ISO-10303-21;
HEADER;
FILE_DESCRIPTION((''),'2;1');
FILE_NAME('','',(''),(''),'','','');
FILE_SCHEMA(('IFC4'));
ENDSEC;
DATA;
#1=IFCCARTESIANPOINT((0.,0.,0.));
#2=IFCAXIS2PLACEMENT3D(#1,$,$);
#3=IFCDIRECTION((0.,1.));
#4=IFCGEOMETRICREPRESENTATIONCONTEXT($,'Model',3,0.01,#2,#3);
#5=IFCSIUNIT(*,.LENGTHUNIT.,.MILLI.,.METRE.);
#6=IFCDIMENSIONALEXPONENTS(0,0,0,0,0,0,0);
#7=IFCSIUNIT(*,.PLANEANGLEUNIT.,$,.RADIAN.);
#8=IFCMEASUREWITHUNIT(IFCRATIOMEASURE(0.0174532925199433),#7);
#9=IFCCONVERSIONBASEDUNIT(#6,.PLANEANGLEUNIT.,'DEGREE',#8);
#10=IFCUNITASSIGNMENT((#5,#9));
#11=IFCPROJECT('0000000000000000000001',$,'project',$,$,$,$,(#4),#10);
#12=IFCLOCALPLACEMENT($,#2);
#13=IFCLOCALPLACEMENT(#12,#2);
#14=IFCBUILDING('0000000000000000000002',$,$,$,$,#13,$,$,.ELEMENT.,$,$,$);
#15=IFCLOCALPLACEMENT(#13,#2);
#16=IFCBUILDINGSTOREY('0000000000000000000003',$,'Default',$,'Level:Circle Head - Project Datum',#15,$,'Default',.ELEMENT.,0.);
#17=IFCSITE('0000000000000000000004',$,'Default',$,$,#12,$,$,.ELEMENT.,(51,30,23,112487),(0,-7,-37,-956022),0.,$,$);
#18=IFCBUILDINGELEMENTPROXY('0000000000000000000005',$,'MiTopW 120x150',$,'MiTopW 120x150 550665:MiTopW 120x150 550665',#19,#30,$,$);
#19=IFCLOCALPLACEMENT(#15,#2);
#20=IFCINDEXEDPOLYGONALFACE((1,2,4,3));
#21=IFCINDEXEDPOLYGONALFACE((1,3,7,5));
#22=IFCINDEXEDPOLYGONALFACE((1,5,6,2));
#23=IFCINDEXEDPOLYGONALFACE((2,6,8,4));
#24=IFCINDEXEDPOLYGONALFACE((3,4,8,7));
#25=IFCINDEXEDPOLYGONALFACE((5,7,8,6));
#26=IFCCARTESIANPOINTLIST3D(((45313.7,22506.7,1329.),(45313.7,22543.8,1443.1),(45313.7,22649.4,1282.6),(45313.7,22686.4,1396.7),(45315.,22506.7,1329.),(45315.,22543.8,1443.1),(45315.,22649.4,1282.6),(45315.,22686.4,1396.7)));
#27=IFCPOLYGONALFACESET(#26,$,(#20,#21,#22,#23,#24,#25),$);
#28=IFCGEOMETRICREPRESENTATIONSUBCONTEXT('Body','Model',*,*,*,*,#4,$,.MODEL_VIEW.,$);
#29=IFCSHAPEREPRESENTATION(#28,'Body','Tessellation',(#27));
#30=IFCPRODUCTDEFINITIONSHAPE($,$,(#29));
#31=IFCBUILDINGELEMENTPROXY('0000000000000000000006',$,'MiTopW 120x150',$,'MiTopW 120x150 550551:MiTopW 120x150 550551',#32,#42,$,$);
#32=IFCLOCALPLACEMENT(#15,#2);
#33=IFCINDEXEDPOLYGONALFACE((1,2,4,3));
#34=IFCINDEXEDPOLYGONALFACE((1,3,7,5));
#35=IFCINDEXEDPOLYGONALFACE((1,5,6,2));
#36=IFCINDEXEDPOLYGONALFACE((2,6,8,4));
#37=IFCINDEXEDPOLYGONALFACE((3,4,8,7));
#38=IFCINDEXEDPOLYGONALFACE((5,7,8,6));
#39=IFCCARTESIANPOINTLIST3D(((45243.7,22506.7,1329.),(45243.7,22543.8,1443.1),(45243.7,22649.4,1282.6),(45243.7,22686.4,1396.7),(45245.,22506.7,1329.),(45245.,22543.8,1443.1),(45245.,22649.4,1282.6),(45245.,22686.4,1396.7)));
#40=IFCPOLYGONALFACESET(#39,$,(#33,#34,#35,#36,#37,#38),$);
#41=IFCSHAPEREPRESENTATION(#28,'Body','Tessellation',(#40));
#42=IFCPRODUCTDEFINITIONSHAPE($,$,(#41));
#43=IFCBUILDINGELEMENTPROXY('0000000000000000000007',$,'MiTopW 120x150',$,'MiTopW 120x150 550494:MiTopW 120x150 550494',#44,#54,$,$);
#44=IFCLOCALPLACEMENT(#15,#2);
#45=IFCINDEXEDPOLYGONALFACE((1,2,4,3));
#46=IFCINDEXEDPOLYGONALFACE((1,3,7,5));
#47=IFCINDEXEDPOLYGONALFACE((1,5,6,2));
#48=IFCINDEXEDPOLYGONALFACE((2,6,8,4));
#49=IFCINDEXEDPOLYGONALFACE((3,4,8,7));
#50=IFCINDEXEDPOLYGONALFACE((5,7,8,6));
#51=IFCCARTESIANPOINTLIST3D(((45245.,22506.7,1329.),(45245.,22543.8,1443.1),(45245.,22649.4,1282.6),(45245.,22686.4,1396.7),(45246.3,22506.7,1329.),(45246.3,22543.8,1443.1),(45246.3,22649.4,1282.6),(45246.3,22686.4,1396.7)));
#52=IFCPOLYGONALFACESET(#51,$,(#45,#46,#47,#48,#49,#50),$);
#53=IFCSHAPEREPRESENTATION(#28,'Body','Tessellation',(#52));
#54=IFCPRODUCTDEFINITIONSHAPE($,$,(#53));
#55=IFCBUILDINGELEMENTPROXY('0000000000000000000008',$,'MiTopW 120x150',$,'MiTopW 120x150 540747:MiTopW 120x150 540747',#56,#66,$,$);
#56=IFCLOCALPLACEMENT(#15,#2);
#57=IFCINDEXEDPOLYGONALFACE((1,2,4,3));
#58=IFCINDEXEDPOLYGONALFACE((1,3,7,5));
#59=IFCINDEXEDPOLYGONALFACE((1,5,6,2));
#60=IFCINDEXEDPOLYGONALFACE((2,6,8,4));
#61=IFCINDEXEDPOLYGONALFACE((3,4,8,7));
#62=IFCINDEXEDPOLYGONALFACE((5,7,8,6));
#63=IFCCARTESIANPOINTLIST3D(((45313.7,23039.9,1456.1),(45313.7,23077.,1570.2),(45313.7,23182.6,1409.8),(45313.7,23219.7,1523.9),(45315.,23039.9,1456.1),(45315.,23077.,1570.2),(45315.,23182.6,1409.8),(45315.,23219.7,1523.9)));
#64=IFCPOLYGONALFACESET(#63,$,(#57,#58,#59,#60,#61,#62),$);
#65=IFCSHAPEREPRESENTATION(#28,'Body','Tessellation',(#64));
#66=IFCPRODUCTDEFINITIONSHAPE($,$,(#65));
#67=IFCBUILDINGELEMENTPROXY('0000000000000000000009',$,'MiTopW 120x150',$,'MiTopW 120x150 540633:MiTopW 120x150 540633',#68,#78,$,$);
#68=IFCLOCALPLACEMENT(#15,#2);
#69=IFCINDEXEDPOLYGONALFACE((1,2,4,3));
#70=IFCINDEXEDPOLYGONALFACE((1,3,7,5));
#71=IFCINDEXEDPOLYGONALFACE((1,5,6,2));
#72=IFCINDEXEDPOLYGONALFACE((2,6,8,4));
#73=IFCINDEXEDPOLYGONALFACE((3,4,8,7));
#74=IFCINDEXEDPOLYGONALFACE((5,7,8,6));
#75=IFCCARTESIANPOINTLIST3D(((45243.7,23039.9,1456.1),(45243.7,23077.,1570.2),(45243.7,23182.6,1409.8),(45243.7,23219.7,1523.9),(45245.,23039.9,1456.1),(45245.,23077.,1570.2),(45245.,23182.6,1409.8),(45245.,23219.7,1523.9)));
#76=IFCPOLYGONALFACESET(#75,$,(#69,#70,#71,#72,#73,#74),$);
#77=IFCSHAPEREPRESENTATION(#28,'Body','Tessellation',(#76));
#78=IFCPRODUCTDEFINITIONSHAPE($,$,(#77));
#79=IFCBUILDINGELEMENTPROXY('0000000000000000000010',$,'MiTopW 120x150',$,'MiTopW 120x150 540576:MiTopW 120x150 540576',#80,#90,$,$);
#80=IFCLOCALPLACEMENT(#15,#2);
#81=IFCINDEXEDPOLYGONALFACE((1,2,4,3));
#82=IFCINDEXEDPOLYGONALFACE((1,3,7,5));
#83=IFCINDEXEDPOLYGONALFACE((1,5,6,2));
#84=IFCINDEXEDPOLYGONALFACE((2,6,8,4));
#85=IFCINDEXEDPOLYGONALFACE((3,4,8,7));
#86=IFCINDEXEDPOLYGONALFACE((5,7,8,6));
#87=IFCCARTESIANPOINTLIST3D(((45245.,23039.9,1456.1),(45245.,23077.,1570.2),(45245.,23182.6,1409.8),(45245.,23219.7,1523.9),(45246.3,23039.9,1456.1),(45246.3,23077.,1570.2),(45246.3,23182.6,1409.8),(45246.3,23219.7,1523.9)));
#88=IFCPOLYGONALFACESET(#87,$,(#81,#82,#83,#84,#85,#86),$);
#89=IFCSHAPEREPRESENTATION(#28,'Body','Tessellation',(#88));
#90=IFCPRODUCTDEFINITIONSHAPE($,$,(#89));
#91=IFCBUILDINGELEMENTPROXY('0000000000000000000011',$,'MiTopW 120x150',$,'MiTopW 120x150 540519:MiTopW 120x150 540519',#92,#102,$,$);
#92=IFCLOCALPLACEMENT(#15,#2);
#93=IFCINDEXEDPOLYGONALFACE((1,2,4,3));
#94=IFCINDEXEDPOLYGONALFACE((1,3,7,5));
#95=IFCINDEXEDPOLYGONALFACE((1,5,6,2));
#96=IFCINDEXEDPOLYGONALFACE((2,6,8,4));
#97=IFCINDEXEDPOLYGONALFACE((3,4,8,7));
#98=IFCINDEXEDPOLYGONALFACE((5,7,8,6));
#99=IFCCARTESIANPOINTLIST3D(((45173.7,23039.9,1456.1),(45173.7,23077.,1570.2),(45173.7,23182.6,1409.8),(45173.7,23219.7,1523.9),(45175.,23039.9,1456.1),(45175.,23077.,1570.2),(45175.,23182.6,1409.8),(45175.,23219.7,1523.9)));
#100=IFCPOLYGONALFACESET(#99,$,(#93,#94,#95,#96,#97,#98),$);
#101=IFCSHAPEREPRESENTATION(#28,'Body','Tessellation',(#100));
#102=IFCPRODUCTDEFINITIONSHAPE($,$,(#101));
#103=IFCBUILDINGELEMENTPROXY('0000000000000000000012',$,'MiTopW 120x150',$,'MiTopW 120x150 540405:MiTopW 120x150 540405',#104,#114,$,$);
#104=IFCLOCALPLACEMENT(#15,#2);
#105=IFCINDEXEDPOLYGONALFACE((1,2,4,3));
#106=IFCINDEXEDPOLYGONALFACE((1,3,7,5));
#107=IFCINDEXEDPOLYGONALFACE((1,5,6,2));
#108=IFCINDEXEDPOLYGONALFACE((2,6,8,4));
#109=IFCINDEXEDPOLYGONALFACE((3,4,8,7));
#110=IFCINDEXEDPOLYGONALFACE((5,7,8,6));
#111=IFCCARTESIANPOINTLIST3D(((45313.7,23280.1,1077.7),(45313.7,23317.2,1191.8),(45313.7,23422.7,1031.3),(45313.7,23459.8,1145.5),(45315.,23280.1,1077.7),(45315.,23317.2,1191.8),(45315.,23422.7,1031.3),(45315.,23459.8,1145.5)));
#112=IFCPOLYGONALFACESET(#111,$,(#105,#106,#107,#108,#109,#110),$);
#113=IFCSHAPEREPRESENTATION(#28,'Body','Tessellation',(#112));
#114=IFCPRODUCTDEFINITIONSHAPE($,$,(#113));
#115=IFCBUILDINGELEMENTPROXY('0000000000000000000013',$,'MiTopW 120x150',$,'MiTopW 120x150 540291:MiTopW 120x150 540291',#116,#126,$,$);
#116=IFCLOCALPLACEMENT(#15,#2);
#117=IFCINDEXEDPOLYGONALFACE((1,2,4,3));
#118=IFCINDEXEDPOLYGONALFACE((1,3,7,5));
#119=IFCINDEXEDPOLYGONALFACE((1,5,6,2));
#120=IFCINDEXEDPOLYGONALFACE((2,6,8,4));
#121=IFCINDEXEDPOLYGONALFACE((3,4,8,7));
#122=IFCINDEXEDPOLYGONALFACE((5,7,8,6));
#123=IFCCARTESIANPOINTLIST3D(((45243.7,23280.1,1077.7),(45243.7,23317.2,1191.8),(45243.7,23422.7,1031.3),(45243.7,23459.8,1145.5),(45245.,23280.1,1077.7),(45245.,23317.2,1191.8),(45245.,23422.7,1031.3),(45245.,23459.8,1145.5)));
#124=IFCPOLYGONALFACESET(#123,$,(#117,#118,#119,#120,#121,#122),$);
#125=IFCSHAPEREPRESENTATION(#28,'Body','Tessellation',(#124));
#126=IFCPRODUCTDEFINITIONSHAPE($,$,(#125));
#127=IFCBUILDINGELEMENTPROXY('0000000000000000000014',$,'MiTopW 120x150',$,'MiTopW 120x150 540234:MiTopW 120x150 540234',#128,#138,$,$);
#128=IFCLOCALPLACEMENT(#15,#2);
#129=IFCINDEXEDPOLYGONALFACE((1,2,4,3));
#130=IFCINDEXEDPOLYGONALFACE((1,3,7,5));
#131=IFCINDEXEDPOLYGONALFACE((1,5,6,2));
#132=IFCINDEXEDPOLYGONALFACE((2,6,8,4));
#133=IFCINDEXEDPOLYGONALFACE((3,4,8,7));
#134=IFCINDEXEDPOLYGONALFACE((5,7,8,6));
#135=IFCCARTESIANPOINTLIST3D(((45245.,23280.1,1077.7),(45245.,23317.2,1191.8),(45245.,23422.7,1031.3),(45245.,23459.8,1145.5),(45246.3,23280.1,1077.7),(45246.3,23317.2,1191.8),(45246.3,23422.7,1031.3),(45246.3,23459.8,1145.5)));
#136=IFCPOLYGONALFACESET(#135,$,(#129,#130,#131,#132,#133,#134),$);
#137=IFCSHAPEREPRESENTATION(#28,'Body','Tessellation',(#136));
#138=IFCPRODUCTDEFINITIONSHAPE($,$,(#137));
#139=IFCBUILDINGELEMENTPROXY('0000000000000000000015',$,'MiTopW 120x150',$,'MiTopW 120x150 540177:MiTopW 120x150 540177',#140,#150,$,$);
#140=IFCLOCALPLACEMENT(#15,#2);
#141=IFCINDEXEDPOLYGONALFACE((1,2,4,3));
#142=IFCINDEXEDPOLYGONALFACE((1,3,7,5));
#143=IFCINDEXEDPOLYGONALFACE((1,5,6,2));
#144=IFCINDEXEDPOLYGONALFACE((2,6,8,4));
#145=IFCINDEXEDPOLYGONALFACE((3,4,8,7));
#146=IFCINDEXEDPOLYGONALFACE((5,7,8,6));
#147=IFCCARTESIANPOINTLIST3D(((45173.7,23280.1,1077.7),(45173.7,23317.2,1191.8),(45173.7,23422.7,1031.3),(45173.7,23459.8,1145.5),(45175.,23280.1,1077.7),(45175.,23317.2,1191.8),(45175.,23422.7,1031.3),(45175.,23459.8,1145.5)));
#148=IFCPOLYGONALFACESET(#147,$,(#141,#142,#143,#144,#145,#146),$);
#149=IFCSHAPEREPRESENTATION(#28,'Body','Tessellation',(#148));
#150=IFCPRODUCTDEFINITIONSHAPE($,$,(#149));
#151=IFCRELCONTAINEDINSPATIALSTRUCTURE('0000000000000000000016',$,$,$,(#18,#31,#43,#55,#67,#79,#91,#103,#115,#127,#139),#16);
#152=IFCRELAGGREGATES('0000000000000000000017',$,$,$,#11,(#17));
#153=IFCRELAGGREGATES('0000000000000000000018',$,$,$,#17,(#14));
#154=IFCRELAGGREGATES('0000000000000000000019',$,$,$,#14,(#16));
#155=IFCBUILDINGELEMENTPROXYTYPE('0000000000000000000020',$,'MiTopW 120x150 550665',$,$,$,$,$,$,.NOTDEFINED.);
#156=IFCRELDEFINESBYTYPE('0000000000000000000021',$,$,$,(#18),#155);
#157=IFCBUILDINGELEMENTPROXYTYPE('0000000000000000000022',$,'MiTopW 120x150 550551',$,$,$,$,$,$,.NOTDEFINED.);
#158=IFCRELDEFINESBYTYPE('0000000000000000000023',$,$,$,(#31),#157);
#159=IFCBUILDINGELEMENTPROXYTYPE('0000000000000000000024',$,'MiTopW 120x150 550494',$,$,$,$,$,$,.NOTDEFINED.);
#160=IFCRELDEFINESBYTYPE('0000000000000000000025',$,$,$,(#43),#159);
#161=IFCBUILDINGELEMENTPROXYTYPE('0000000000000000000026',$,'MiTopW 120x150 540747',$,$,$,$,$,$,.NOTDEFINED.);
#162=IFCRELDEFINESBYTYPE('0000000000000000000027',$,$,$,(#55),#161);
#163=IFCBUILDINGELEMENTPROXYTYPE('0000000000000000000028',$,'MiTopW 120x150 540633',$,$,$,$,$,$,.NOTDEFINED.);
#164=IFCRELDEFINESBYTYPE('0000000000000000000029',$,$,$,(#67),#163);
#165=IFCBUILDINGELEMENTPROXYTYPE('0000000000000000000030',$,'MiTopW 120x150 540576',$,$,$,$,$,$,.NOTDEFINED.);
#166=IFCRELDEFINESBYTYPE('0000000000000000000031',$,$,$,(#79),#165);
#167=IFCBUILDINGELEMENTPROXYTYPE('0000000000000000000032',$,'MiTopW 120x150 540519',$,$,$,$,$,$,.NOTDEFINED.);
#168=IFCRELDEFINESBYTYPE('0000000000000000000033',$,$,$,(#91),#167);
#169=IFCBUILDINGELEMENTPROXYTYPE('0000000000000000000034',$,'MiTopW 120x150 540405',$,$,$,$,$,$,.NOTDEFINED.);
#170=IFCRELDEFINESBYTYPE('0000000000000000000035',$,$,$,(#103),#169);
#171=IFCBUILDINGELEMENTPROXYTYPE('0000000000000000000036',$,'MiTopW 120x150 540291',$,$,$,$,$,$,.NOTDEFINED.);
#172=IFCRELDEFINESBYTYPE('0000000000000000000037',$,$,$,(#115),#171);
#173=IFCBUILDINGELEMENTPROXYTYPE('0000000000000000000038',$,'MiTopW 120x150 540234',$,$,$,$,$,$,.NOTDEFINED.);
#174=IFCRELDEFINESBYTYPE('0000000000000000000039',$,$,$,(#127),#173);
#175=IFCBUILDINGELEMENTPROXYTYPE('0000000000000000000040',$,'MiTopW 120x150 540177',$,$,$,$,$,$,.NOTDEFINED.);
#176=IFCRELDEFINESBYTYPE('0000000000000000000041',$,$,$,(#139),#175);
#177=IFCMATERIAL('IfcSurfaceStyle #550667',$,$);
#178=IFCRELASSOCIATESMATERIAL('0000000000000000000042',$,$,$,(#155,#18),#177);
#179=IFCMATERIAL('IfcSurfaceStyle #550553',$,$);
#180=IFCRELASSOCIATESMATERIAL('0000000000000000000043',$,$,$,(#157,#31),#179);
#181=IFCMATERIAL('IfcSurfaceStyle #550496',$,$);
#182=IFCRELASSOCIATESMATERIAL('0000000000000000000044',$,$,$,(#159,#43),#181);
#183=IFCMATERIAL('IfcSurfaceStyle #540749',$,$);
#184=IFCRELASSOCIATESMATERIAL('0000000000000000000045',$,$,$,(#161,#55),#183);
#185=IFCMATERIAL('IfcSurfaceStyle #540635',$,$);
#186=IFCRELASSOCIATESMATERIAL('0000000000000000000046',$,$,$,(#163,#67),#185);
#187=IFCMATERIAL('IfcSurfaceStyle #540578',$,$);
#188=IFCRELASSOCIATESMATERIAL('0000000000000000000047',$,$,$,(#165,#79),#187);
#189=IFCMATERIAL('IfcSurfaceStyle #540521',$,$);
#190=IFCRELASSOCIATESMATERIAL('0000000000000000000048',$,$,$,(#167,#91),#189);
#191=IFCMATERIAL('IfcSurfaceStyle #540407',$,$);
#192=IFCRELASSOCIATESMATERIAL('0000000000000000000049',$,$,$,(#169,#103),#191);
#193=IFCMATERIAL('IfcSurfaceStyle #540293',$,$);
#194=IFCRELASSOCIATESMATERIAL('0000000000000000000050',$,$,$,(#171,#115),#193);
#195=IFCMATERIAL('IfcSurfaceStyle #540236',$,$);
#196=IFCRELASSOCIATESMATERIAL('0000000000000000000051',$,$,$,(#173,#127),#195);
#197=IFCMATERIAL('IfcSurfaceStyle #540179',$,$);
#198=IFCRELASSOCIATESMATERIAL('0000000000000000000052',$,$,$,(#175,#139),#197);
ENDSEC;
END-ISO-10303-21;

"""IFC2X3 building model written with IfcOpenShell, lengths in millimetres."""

from ifc_helpers import new_model, entity, si_unit, converted_unit, direction, frame, origin, place, context, subcontext, project, spatial, polyline, outline, extrude, source, transform, mapped, material, type_object, type_shapes, element, save


model = new_model("IFC2X3")

# Units and contexts
model_context = context("Model", 3, precision=0.01, world=origin(), true_north=direction((0.0, 1.0)))
body_context = subcontext(model_context, "Body", "Model", "MODEL_VIEW")
ifc_project = project(units=[si_unit("LENGTHUNIT", "METRE", prefix="MILLI"), converted_unit("PLANEANGLEUNIT", "DEGREE", entity("IfcRatioMeasure", 0.0174532925199433), si_unit("PLANEANGLEUNIT", "RADIAN"), dimensions=[0, 0, 0, 0, 0, 0, 0])], contexts=[model_context])

# Site, building, storey
site_placement = place(None, origin())
site = spatial("IfcSite", under=ifc_project, at=site_placement, Name="Default", CompositionType="ELEMENT", RefLatitude=(51, 30, 23, 112487), RefLongitude=(0, -7, -37, -956022), RefElevation=0.0)
building_placement = place(site_placement, origin())
building = spatial("IfcBuilding", under=site, at=building_placement, CompositionType="ELEMENT")
storey_placement = place(building_placement, origin())
storey = spatial("IfcBuildingStorey", under=building, at=storey_placement, Name="Default", ObjectType="Level:Circle Head - Project Datum", LongName="Default", CompositionType="ELEMENT", Elevation=0.0)

# Building element proxies
ifc_material_1 = material(Name="IfcSurfaceStyle #550667")
building_element_proxy_type_1 = type_object("IfcBuildingElementProxyType", Name="MiTopW 120x150 550665", PredefinedType="NOTDEFINED", material=ifc_material_1)
shared_shape_1 = source(origin(), body_context, "Body", "SweptSolid", [
    extrude(outline(polyline([(-75.0, -60.0), (75.0, -60.0), (75.0, 60.0), (-75.0, 60.0), (-75.0, -60.0)])), frame((75.0, 60.0, 0.0), z_axis=(0.0, 0.0, 1.0), x_axis=(-1.0, 0.0, 0.0)), (0.0, 0.0, 1.0), 1.3),
])
type_shapes(building_element_proxy_type_1, [shared_shape_1])
proxy_1_placement = place(building_placement, frame((45315.0, 22649.4, 1282.6), z_axis=(-1.0, 0.0, 0.0), x_axis=(0.0, -0.951057, 0.309017)))
element("IfcBuildingElementProxy", 1, at=proxy_1_placement, inside=storey, type_object=building_element_proxy_type_1, material=ifc_material_1, Name="MiTopW 120x150", ObjectType="MiTopW 120x150 550665:MiTopW 120x150 550665", context=body_context, shape_type="MappedRepresentation", body=[
    mapped(shared_shape_1, transform((0.0, 0.0, 0.0), scale=1.0)),
])
ifc_material_2 = material(Name="IfcSurfaceStyle #550553")
building_element_proxy_type_2 = type_object("IfcBuildingElementProxyType", Name="MiTopW 120x150 550551", PredefinedType="NOTDEFINED", material=ifc_material_2)
shared_shape_2 = source(origin(), body_context, "Body", "SweptSolid", [
    extrude(outline(polyline([(-75.0, -60.0), (75.0, -60.0), (75.0, 60.0), (-75.0, 60.0), (-75.0, -60.0)])), frame((75.0, 60.0, 0.0), z_axis=(0.0, 0.0, 1.0), x_axis=(-1.0, 0.0, 0.0)), (0.0, 0.0, 1.0), 1.3),
])
type_shapes(building_element_proxy_type_2, [shared_shape_2])
proxy_2_placement = place(building_placement, frame((45245.0, 22649.4, 1282.6), z_axis=(-1.0, 0.0, 0.0), x_axis=(0.0, -0.951057, 0.309017)))
element("IfcBuildingElementProxy", 2, at=proxy_2_placement, inside=storey, type_object=building_element_proxy_type_2, material=ifc_material_2, Name="MiTopW 120x150", ObjectType="MiTopW 120x150 550551:MiTopW 120x150 550551", context=body_context, shape_type="MappedRepresentation", body=[
    mapped(shared_shape_2, transform((0.0, 0.0, 0.0), scale=1.0)),
])
ifc_material_3 = material(Name="IfcSurfaceStyle #550496")
building_element_proxy_type_3 = type_object("IfcBuildingElementProxyType", Name="MiTopW 120x150 550494", PredefinedType="NOTDEFINED", material=ifc_material_3)
shared_shape_3 = source(origin(), body_context, "Body", "SweptSolid", [
    extrude(outline(polyline([(-75.0, -60.0), (75.0, -60.0), (75.0, 60.0), (-75.0, 60.0), (-75.0, -60.0)])), frame((75.0, 60.0, 0.0), z_axis=(0.0, 0.0, 1.0), x_axis=(-1.0, 0.0, 0.0)), (0.0, 0.0, 1.0), 1.3),
])
type_shapes(building_element_proxy_type_3, [shared_shape_3])
proxy_3_placement = place(building_placement, frame((45246.3, 22649.4, 1282.6), z_axis=(-1.0, 0.0, 0.0), x_axis=(0.0, -0.951057, 0.309017)))
element("IfcBuildingElementProxy", 3, at=proxy_3_placement, inside=storey, type_object=building_element_proxy_type_3, material=ifc_material_3, Name="MiTopW 120x150", ObjectType="MiTopW 120x150 550494:MiTopW 120x150 550494", context=body_context, shape_type="MappedRepresentation", body=[
    mapped(shared_shape_3, transform((0.0, 0.0, 0.0), scale=1.0)),
])
ifc_material_4 = material(Name="IfcSurfaceStyle #540749")
building_element_proxy_type_4 = type_object("IfcBuildingElementProxyType", Name="MiTopW 120x150 540747", PredefinedType="NOTDEFINED", material=ifc_material_4)
shared_shape_4 = source(origin(), body_context, "Body", "SweptSolid", [
    extrude(outline(polyline([(-75.0, -60.0), (75.0, -60.0), (75.0, 60.0), (-75.0, 60.0), (-75.0, -60.0)])), frame((75.0, 60.0, 0.0), z_axis=(0.0, 0.0, 1.0), x_axis=(-1.0, 0.0, 0.0)), (0.0, 0.0, 1.0), 1.3),
])
type_shapes(building_element_proxy_type_4, [shared_shape_4])
proxy_4_placement = place(building_placement, frame((45315.0, 23182.6, 1409.8), z_axis=(-1.0, 0.0, 0.0), x_axis=(0.0, -0.951057, 0.309017)))
element("IfcBuildingElementProxy", 4, at=proxy_4_placement, inside=storey, type_object=building_element_proxy_type_4, material=ifc_material_4, Name="MiTopW 120x150", ObjectType="MiTopW 120x150 540747:MiTopW 120x150 540747", context=body_context, shape_type="MappedRepresentation", body=[
    mapped(shared_shape_4, transform((0.0, 0.0, 0.0), scale=1.0)),
])
ifc_material_5 = material(Name="IfcSurfaceStyle #540635")
building_element_proxy_type_5 = type_object("IfcBuildingElementProxyType", Name="MiTopW 120x150 540633", PredefinedType="NOTDEFINED", material=ifc_material_5)
shared_shape_5 = source(origin(), body_context, "Body", "SweptSolid", [
    extrude(outline(polyline([(-75.0, -60.0), (75.0, -60.0), (75.0, 60.0), (-75.0, 60.0), (-75.0, -60.0)])), frame((75.0, 60.0, 0.0), z_axis=(0.0, 0.0, 1.0), x_axis=(-1.0, 0.0, 0.0)), (0.0, 0.0, 1.0), 1.3),
])
type_shapes(building_element_proxy_type_5, [shared_shape_5])
proxy_5_placement = place(building_placement, frame((45245.0, 23182.6, 1409.8), z_axis=(-1.0, 0.0, 0.0), x_axis=(0.0, -0.951057, 0.309017)))
element("IfcBuildingElementProxy", 5, at=proxy_5_placement, inside=storey, type_object=building_element_proxy_type_5, material=ifc_material_5, Name="MiTopW 120x150", ObjectType="MiTopW 120x150 540633:MiTopW 120x150 540633", context=body_context, shape_type="MappedRepresentation", body=[
    mapped(shared_shape_5, transform((0.0, 0.0, 0.0), scale=1.0)),
])
ifc_material_6 = material(Name="IfcSurfaceStyle #540578")
building_element_proxy_type_6 = type_object("IfcBuildingElementProxyType", Name="MiTopW 120x150 540576", PredefinedType="NOTDEFINED", material=ifc_material_6)
shared_shape_6 = source(origin(), body_context, "Body", "SweptSolid", [
    extrude(outline(polyline([(-75.0, -60.0), (75.0, -60.0), (75.0, 60.0), (-75.0, 60.0), (-75.0, -60.0)])), frame((75.0, 60.0, 0.0), z_axis=(0.0, 0.0, 1.0), x_axis=(-1.0, 0.0, 0.0)), (0.0, 0.0, 1.0), 1.3),
])
type_shapes(building_element_proxy_type_6, [shared_shape_6])
proxy_6_placement = place(building_placement, frame((45246.3, 23182.6, 1409.8), z_axis=(-1.0, 0.0, 0.0), x_axis=(0.0, -0.951057, 0.309017)))
element("IfcBuildingElementProxy", 6, at=proxy_6_placement, inside=storey, type_object=building_element_proxy_type_6, material=ifc_material_6, Name="MiTopW 120x150", ObjectType="MiTopW 120x150 540576:MiTopW 120x150 540576", context=body_context, shape_type="MappedRepresentation", body=[
    mapped(shared_shape_6, transform((0.0, 0.0, 0.0), scale=1.0)),
])
ifc_material_7 = material(Name="IfcSurfaceStyle #540521")
building_element_proxy_type_7 = type_object("IfcBuildingElementProxyType", Name="MiTopW 120x150 540519", PredefinedType="NOTDEFINED", material=ifc_material_7)
shared_shape_7 = source(origin(), body_context, "Body", "SweptSolid", [
    extrude(outline(polyline([(-75.0, -60.0), (75.0, -60.0), (75.0, 60.0), (-75.0, 60.0), (-75.0, -60.0)])), frame((75.0, 60.0, 0.0), z_axis=(0.0, 0.0, 1.0), x_axis=(-1.0, 0.0, 0.0)), (0.0, 0.0, 1.0), 1.3),
])
type_shapes(building_element_proxy_type_7, [shared_shape_7])
proxy_7_placement = place(building_placement, frame((45175.0, 23182.6, 1409.8), z_axis=(-1.0, 0.0, 0.0), x_axis=(0.0, -0.951057, 0.309017)))
element("IfcBuildingElementProxy", 7, at=proxy_7_placement, inside=storey, type_object=building_element_proxy_type_7, material=ifc_material_7, Name="MiTopW 120x150", ObjectType="MiTopW 120x150 540519:MiTopW 120x150 540519", context=body_context, shape_type="MappedRepresentation", body=[
    mapped(shared_shape_7, transform((0.0, 0.0, 0.0), scale=1.0)),
])
ifc_material_8 = material(Name="IfcSurfaceStyle #540407")
building_element_proxy_type_8 = type_object("IfcBuildingElementProxyType", Name="MiTopW 120x150 540405", PredefinedType="NOTDEFINED", material=ifc_material_8)
shared_shape_8 = source(origin(), body_context, "Body", "SweptSolid", [
    extrude(outline(polyline([(-75.0, -60.0), (75.0, -60.0), (75.0, 60.0), (-75.0, 60.0), (-75.0, -60.0)])), frame((75.0, 60.0, 0.0), z_axis=(0.0, 0.0, 1.0), x_axis=(-1.0, 0.0, 0.0)), (0.0, 0.0, 1.0), 1.3),
])
type_shapes(building_element_proxy_type_8, [shared_shape_8])
proxy_8_placement = place(building_placement, frame((45315.0, 23422.7, 1031.3), z_axis=(-1.0, 0.0, 0.0), x_axis=(0.0, -0.951057, 0.309017)))
element("IfcBuildingElementProxy", 8, at=proxy_8_placement, inside=storey, type_object=building_element_proxy_type_8, material=ifc_material_8, Name="MiTopW 120x150", ObjectType="MiTopW 120x150 540405:MiTopW 120x150 540405", context=body_context, shape_type="MappedRepresentation", body=[
    mapped(shared_shape_8, transform((0.0, 0.0, 0.0), scale=1.0)),
])
ifc_material_9 = material(Name="IfcSurfaceStyle #540293")
building_element_proxy_type_9 = type_object("IfcBuildingElementProxyType", Name="MiTopW 120x150 540291", PredefinedType="NOTDEFINED", material=ifc_material_9)
shared_shape_9 = source(origin(), body_context, "Body", "SweptSolid", [
    extrude(outline(polyline([(-75.0, -60.0), (75.0, -60.0), (75.0, 60.0), (-75.0, 60.0), (-75.0, -60.0)])), frame((75.0, 60.0, 0.0), z_axis=(0.0, 0.0, 1.0), x_axis=(-1.0, 0.0, 0.0)), (0.0, 0.0, 1.0), 1.3),
])
type_shapes(building_element_proxy_type_9, [shared_shape_9])
proxy_9_placement = place(building_placement, frame((45245.0, 23422.7, 1031.3), z_axis=(-1.0, 0.0, 0.0), x_axis=(0.0, -0.951057, 0.309017)))
element("IfcBuildingElementProxy", 9, at=proxy_9_placement, inside=storey, type_object=building_element_proxy_type_9, material=ifc_material_9, Name="MiTopW 120x150", ObjectType="MiTopW 120x150 540291:MiTopW 120x150 540291", context=body_context, shape_type="MappedRepresentation", body=[
    mapped(shared_shape_9, transform((0.0, 0.0, 0.0), scale=1.0)),
])
ifc_material_10 = material(Name="IfcSurfaceStyle #540236")
building_element_proxy_type_10 = type_object("IfcBuildingElementProxyType", Name="MiTopW 120x150 540234", PredefinedType="NOTDEFINED", material=ifc_material_10)
shared_shape_10 = source(origin(), body_context, "Body", "SweptSolid", [
    extrude(outline(polyline([(-75.0, -60.0), (75.0, -60.0), (75.0, 60.0), (-75.0, 60.0), (-75.0, -60.0)])), frame((75.0, 60.0, 0.0), z_axis=(0.0, 0.0, 1.0), x_axis=(-1.0, 0.0, 0.0)), (0.0, 0.0, 1.0), 1.3),
])
type_shapes(building_element_proxy_type_10, [shared_shape_10])
proxy_10_placement = place(building_placement, frame((45246.3, 23422.7, 1031.3), z_axis=(-1.0, 0.0, 0.0), x_axis=(0.0, -0.951057, 0.309017)))
element("IfcBuildingElementProxy", 10, at=proxy_10_placement, inside=storey, type_object=building_element_proxy_type_10, material=ifc_material_10, Name="MiTopW 120x150", ObjectType="MiTopW 120x150 540234:MiTopW 120x150 540234", context=body_context, shape_type="MappedRepresentation", body=[
    mapped(shared_shape_10, transform((0.0, 0.0, 0.0), scale=1.0)),
])
ifc_material_11 = material(Name="IfcSurfaceStyle #540179")
building_element_proxy_type_11 = type_object("IfcBuildingElementProxyType", Name="MiTopW 120x150 540177", PredefinedType="NOTDEFINED", material=ifc_material_11)
shared_shape_11 = source(origin(), body_context, "Body", "SweptSolid", [
    extrude(outline(polyline([(-75.0, -60.0), (75.0, -60.0), (75.0, 60.0), (-75.0, 60.0), (-75.0, -60.0)])), frame((75.0, 60.0, 0.0), z_axis=(0.0, 0.0, 1.0), x_axis=(-1.0, 0.0, 0.0)), (0.0, 0.0, 1.0), 1.3),
])
type_shapes(building_element_proxy_type_11, [shared_shape_11])
proxy_11_placement = place(building_placement, frame((45175.0, 23422.7, 1031.3), z_axis=(-1.0, 0.0, 0.0), x_axis=(0.0, -0.951057, 0.309017)))
element("IfcBuildingElementProxy", 11, at=proxy_11_placement, inside=storey, type_object=building_element_proxy_type_11, material=ifc_material_11, Name="MiTopW 120x150", ObjectType="MiTopW 120x150 540177:MiTopW 120x150 540177", context=body_context, shape_type="MappedRepresentation", body=[
    mapped(shared_shape_11, transform((0.0, 0.0, 0.0), scale=1.0)),
])

save(model, "model.ifc")
